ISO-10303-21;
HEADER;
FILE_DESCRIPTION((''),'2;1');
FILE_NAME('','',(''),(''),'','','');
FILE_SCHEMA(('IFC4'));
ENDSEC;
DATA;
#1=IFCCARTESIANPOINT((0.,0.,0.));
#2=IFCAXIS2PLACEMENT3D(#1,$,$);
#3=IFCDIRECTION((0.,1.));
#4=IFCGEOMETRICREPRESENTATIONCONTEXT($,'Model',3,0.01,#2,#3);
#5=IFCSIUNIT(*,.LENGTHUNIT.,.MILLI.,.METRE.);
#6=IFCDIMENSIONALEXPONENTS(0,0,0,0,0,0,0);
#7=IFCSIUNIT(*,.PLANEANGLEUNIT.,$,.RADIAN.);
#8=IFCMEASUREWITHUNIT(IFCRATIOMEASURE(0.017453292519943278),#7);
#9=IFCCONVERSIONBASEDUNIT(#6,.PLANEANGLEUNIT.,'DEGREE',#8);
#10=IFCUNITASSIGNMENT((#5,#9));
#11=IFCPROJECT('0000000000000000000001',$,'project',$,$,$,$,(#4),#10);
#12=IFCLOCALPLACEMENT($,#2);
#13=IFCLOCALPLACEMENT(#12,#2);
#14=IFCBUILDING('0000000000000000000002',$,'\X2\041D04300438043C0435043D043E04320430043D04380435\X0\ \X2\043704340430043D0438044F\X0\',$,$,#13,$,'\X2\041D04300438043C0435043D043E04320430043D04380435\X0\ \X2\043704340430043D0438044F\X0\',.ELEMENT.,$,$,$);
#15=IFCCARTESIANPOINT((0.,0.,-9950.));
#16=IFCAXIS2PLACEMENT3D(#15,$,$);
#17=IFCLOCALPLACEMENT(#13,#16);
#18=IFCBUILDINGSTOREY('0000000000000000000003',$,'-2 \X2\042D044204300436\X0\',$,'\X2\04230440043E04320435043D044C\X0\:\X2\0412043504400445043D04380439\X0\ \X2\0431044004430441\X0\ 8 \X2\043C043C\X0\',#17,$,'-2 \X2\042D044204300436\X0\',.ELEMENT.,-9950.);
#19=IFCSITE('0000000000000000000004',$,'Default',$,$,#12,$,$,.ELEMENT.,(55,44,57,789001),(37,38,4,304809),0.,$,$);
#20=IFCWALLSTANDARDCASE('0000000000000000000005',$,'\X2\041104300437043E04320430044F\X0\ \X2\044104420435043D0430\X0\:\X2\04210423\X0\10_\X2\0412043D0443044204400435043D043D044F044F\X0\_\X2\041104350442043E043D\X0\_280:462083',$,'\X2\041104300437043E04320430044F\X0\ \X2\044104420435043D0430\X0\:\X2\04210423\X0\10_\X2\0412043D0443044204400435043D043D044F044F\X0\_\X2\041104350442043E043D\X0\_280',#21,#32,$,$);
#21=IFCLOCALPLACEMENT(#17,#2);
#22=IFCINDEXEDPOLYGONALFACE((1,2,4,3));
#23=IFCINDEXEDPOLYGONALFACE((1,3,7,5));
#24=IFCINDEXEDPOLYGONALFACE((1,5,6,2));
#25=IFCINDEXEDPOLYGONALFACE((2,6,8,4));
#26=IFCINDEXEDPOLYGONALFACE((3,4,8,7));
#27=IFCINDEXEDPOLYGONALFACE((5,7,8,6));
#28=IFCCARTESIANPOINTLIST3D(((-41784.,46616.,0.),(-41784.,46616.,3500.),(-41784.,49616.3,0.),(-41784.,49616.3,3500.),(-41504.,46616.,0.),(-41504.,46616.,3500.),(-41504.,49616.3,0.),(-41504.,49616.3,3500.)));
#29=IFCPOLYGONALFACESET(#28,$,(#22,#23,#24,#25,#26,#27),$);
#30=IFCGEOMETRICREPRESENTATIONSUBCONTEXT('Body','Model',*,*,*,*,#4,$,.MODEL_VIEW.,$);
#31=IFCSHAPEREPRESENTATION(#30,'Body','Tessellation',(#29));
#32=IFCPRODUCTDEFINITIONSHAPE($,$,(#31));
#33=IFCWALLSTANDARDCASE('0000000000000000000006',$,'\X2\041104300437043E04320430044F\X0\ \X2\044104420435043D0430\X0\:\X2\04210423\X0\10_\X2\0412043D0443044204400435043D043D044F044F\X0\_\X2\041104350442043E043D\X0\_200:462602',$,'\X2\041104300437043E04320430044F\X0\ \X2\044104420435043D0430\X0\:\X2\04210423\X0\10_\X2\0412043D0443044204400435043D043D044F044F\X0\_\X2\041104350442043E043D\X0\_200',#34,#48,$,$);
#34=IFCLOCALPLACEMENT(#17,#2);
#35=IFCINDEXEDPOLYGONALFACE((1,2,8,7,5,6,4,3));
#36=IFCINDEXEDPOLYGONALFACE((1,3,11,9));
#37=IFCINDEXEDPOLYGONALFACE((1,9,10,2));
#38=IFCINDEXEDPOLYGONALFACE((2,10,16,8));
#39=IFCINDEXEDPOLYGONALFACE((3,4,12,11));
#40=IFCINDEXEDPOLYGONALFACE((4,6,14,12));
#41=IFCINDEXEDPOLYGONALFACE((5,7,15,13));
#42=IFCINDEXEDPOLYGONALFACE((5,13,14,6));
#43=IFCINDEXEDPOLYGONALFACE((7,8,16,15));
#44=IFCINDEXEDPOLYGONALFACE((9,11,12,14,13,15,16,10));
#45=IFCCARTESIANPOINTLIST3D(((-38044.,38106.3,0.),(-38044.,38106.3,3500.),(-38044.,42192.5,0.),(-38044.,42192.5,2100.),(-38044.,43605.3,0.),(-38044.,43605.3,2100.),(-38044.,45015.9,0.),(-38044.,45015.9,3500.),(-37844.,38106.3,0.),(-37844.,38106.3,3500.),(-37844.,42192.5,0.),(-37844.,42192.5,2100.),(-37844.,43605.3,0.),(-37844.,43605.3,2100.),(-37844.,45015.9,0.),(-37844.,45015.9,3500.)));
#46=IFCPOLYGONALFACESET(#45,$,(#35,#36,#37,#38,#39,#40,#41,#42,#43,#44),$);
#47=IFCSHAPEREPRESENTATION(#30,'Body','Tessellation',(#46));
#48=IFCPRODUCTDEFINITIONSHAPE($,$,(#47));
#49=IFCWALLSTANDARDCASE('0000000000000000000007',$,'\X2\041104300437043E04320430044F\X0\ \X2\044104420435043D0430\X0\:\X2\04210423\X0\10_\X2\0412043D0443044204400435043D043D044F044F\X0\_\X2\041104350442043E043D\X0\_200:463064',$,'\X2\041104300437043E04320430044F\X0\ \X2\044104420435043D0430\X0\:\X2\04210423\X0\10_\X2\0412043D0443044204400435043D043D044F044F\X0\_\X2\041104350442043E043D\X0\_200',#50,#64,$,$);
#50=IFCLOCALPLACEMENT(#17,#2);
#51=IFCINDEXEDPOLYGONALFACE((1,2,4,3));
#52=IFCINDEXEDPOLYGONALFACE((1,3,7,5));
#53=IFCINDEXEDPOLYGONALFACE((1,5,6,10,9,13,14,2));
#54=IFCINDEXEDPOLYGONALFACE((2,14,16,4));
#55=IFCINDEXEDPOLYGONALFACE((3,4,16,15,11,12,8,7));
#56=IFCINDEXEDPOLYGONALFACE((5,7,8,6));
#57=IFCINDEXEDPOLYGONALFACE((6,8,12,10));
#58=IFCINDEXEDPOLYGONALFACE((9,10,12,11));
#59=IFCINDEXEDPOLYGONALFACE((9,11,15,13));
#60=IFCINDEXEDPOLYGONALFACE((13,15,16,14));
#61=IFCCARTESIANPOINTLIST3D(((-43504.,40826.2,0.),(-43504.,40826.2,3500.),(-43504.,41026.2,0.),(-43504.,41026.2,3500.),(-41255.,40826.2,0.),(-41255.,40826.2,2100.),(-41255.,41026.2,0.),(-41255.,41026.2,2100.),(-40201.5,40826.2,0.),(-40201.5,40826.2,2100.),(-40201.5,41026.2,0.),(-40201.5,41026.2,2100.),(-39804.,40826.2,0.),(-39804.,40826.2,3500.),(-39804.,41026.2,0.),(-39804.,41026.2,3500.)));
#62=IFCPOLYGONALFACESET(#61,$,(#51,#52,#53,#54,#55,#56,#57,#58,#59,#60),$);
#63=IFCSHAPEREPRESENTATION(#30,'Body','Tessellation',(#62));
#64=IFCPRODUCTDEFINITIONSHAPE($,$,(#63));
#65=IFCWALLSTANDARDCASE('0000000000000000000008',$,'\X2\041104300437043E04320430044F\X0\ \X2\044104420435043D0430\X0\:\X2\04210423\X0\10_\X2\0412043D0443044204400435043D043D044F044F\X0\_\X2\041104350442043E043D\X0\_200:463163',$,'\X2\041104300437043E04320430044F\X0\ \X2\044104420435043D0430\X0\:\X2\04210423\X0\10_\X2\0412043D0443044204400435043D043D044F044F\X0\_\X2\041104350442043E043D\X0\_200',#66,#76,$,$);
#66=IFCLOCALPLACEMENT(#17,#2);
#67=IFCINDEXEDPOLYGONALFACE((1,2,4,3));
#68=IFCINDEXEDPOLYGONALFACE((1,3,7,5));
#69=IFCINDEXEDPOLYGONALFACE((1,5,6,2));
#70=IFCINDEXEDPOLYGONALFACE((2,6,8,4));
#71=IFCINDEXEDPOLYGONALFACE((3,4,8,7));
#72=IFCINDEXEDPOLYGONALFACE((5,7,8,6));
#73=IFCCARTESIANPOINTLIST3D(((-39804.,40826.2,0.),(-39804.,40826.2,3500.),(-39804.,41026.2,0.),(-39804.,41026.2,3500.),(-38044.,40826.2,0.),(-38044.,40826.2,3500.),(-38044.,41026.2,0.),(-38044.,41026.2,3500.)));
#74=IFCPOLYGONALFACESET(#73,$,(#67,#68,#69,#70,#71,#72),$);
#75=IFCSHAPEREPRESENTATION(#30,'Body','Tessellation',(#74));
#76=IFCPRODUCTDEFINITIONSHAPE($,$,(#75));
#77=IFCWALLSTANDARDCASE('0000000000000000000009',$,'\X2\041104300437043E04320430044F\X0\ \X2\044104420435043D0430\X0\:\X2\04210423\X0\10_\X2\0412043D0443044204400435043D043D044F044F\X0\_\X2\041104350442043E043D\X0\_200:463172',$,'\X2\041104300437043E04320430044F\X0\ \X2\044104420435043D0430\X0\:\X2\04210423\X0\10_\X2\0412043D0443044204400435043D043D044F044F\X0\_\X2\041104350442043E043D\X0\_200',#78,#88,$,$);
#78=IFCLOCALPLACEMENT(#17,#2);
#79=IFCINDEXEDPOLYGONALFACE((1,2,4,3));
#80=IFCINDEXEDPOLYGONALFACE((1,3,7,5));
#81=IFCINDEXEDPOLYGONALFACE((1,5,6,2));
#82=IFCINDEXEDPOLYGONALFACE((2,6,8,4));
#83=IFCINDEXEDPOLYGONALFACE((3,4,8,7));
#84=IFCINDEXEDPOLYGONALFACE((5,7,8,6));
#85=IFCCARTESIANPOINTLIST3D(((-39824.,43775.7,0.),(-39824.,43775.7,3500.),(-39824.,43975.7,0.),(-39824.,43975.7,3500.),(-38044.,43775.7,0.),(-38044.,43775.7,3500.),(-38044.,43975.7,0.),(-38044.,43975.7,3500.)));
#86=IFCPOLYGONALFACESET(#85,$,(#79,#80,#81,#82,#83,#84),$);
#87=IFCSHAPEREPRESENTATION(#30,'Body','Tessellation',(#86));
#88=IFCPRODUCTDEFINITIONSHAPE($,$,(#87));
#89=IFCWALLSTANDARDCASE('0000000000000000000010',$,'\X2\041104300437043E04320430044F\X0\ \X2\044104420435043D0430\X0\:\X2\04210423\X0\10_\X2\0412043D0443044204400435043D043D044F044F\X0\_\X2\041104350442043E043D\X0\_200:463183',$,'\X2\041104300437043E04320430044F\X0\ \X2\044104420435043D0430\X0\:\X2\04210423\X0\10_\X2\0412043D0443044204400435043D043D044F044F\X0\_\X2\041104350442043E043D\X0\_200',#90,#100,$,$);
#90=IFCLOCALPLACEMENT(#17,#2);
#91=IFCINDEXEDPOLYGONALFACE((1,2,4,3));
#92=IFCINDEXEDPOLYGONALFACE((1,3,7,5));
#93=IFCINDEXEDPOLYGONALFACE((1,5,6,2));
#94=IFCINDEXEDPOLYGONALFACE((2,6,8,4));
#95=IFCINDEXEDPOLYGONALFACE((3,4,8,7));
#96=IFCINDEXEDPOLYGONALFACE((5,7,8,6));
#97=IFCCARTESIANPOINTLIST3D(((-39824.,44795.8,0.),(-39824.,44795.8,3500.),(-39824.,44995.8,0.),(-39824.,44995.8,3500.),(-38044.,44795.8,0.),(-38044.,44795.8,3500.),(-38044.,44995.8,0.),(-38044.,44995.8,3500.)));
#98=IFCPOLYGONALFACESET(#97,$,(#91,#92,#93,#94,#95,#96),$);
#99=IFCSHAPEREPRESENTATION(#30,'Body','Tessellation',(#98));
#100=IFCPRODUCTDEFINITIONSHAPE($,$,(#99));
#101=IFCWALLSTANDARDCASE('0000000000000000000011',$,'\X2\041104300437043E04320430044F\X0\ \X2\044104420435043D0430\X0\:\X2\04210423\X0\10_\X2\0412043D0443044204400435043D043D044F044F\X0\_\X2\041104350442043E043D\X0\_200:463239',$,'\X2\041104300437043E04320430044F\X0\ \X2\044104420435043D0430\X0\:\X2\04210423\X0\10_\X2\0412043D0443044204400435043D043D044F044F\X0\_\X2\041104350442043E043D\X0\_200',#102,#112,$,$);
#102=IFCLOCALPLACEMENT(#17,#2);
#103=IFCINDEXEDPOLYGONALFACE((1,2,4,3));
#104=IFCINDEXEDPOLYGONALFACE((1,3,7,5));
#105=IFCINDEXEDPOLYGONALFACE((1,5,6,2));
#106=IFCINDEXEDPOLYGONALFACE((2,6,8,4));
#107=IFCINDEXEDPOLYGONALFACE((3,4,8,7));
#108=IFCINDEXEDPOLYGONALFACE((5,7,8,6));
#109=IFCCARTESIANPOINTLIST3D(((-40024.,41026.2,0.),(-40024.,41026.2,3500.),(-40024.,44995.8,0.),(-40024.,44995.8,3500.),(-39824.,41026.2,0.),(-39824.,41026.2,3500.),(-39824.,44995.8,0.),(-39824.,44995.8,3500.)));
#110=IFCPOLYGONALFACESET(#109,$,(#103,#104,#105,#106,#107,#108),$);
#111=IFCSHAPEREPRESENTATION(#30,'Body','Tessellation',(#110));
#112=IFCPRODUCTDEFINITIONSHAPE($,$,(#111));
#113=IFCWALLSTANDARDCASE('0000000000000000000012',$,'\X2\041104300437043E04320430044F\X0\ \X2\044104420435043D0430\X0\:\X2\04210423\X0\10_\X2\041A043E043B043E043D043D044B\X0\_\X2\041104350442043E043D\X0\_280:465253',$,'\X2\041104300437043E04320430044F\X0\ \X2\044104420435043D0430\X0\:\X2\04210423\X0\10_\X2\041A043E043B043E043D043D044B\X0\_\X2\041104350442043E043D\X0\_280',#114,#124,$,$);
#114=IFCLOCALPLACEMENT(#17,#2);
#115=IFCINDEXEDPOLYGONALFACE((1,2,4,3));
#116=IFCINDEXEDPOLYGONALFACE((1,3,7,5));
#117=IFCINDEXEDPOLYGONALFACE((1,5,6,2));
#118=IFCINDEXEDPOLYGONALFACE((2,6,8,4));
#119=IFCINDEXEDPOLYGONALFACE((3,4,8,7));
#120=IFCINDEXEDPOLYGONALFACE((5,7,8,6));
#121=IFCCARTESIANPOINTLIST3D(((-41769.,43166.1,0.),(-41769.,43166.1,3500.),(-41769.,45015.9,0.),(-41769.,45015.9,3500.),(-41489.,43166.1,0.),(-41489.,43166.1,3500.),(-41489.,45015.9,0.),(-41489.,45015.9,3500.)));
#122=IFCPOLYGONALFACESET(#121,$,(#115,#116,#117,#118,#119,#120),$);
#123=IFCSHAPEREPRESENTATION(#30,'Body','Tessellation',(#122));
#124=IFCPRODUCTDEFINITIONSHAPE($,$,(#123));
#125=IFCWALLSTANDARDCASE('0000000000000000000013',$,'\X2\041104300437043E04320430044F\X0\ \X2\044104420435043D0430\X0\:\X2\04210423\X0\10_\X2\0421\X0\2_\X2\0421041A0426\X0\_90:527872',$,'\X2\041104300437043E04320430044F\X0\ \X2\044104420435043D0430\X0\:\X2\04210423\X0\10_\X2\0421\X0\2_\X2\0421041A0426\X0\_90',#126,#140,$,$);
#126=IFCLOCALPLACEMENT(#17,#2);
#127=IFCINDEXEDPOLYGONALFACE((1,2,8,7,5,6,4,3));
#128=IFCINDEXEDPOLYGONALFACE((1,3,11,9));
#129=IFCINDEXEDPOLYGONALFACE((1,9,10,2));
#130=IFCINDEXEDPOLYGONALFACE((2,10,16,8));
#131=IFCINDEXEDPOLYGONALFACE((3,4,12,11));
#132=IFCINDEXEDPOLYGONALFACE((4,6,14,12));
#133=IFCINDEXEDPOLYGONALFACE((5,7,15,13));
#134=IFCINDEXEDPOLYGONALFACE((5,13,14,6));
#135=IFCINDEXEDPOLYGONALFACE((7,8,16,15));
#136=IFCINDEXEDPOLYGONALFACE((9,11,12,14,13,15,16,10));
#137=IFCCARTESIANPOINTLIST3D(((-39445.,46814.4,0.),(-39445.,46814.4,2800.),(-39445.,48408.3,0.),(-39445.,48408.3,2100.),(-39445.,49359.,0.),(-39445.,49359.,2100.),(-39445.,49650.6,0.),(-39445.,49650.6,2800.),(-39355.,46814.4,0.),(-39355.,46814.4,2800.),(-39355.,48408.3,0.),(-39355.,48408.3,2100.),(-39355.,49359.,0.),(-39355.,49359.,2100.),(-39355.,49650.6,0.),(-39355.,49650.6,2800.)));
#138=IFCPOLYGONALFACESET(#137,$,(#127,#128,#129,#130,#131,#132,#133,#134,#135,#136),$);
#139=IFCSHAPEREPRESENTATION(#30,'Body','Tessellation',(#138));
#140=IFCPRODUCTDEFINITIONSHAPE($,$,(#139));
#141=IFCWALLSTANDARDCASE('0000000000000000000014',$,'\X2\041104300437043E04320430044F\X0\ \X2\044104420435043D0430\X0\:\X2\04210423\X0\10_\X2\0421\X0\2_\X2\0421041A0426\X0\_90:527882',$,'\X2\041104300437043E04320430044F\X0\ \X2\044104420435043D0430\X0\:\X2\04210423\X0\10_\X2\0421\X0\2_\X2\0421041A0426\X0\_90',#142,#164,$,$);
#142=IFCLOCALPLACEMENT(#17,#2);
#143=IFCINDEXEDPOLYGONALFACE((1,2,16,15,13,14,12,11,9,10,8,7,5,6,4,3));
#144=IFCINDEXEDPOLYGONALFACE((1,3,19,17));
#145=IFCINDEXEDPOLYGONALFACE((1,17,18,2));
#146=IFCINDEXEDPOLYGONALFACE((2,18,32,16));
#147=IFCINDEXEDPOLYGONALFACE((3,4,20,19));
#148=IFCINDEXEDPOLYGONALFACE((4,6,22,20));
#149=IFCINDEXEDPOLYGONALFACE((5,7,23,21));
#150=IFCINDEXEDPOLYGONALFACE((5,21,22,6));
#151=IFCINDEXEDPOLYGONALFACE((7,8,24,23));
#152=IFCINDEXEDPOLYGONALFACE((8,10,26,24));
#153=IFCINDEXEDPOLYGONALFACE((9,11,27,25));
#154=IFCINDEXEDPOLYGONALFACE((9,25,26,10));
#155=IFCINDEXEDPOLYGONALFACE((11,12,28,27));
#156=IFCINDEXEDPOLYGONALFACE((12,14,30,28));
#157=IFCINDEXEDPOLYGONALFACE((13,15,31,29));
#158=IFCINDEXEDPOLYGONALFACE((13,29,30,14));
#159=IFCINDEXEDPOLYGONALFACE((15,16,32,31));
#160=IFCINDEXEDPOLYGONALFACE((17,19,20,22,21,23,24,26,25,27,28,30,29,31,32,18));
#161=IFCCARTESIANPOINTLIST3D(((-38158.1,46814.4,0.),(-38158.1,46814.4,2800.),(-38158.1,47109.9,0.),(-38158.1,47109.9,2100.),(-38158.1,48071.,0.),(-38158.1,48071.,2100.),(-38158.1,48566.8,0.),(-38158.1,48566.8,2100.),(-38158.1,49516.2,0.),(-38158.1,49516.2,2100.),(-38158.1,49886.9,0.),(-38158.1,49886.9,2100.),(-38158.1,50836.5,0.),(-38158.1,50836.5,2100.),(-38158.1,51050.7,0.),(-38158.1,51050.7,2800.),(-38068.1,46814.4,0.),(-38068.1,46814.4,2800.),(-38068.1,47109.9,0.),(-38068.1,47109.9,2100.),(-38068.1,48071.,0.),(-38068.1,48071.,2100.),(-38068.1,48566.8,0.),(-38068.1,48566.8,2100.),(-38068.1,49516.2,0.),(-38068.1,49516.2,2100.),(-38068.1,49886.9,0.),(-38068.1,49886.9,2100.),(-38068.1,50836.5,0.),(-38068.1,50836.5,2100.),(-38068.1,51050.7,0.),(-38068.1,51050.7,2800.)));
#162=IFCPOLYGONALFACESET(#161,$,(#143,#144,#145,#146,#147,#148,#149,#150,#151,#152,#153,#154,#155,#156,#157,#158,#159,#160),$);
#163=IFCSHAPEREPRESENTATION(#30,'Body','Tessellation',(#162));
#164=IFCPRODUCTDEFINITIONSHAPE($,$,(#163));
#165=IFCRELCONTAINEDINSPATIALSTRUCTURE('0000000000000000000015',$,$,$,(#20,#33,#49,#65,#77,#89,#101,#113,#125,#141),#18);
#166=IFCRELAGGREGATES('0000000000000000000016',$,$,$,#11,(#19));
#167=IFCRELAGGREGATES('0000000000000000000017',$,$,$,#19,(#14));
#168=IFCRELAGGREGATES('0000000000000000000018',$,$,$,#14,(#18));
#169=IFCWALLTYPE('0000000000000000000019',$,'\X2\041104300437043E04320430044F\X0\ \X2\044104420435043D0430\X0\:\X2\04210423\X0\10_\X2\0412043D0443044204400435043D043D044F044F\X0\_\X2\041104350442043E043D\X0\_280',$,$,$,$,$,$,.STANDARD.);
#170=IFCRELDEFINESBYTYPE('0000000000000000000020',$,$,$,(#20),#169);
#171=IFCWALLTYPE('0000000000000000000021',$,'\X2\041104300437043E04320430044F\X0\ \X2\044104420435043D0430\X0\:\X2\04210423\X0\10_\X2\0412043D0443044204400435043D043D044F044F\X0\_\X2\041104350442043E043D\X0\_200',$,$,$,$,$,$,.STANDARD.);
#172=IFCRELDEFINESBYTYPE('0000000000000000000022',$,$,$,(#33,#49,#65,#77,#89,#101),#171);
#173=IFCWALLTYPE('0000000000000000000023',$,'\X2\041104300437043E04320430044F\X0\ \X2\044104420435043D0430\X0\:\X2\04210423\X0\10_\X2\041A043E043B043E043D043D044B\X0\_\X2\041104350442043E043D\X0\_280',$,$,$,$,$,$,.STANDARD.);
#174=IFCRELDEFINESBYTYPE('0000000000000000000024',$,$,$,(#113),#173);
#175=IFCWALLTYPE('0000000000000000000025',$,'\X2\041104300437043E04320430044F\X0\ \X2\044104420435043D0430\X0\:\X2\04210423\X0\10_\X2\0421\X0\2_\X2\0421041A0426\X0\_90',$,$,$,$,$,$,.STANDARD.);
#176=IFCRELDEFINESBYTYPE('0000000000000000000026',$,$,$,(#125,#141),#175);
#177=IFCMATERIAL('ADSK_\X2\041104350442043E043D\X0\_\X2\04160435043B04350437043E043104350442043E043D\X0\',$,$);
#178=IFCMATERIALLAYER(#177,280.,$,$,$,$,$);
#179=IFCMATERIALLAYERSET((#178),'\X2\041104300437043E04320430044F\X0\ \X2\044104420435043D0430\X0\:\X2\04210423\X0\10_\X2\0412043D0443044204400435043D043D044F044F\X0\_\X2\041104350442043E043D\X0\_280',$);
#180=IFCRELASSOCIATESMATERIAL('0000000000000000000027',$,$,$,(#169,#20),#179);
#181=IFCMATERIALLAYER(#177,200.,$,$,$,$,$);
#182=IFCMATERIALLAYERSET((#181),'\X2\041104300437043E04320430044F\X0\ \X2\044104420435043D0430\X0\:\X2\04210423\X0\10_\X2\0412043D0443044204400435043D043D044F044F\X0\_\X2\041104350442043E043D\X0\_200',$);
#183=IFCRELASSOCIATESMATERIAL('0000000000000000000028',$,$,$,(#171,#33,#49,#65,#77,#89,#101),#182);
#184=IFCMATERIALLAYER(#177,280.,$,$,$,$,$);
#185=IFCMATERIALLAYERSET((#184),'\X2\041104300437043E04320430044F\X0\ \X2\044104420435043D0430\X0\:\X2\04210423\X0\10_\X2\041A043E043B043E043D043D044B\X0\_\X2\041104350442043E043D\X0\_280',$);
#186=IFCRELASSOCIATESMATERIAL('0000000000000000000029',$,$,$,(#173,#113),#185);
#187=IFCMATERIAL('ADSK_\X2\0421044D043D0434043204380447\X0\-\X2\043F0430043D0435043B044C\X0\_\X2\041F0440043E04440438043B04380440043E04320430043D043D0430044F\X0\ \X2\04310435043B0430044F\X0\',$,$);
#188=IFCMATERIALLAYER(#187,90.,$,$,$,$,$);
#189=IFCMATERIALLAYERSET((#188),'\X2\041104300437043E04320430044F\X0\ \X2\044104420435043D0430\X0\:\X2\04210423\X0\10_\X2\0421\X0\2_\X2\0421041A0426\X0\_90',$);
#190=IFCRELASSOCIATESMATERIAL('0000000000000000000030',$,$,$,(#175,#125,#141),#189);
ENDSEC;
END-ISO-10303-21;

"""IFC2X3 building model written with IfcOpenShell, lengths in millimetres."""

from ifc_helpers import new_model, entity, si_unit, converted_unit, direction, frame, frame_2d, origin, place, context, subcontext, project, spatial, rectangle, extrude, material, layer, layer_set, layer_usage, type_object, element, save


model = new_model("IFC2X3")

# Units and contexts
model_context = context("Model", 3, precision=0.01, world=origin(), true_north=direction((0.0, 1.0)))
body_context = subcontext(model_context, "Body", "Model", "MODEL_VIEW")
ifc_project = project(units=[si_unit("LENGTHUNIT", "METRE", prefix="MILLI"), converted_unit("PLANEANGLEUNIT", "DEGREE", entity("IfcRatioMeasure", 0.017453292519943278), si_unit("PLANEANGLEUNIT", "RADIAN"), dimensions=[0, 0, 0, 0, 0, 0, 0])], contexts=[model_context])

# Site, building, storey
site_placement = place(None, origin())
site = spatial("IfcSite", under=ifc_project, at=site_placement, Name="Default", CompositionType="ELEMENT", RefLatitude=(55, 44, 57, 789001), RefLongitude=(37, 38, 4, 304809), RefElevation=0.0)
building_placement = place(site_placement, origin())
building = spatial("IfcBuilding", under=site, at=building_placement, Name="Наименование здания", LongName="Наименование здания", CompositionType="ELEMENT")
storey_placement = place(building_placement, frame((0.0, 0.0, -9950.0)))
storey = spatial("IfcBuildingStorey", under=building, at=storey_placement, Name="-2 Этаж", ObjectType="Уровень:Верхний брус 8 мм", LongName="-2 Этаж", CompositionType="ELEMENT", Elevation=-9950.0)

# Wall
ifc_material_1 = material(Name="ADSK_Бетон_Железобетон")
ifc_layer_1 = layer(ifc_material_1, 280.0)
ifc_layer_set_1 = layer_set([ifc_layer_1], Name="Базовая стена:СУ10_Внутренняя_Бетон_280")
ifc_layer_usage_1 = layer_usage(ifc_layer_set_1, "AXIS2", "NEGATIVE", 140.0)
wall_type_1 = type_object("IfcWallType", Name="Базовая стена:СУ10_Внутренняя_Бетон_280", PredefinedType="STANDARD", material=ifc_layer_set_1)
wall_1_placement = place(storey_placement, frame((-41644.0, 49616.3, 0.0), z_axis=(0.0, 0.0, 1.0), x_axis=(0.0, -1.0, 0.0)))
element("IfcWallStandardCase", 1, at=wall_1_placement, inside=storey, type_object=wall_type_1, material=ifc_layer_usage_1, Name="Базовая стена:СУ10_Внутренняя_Бетон_280:462083", ObjectType="Базовая стена:СУ10_Внутренняя_Бетон_280", context=body_context, shape_type="SweptSolid", body=[
    extrude(rectangle(XDim=3000.3, YDim=280.0, at=frame_2d((1500.2, 0.0), x_axis=(-1.0, 0.0))), origin(), (0.0, 0.0, 1.0), 3500.0),
])

# Walls, openings
ifc_layer_2 = layer(ifc_material_1, 200.0)
ifc_layer_set_2 = layer_set([ifc_layer_2], Name="Базовая стена:СУ10_Внутренняя_Бетон_200")
ifc_layer_usage_2 = layer_usage(ifc_layer_set_2, "AXIS2", "NEGATIVE", 100.0)
wall_type_2 = type_object("IfcWallType", Name="Базовая стена:СУ10_Внутренняя_Бетон_200", PredefinedType="STANDARD", material=ifc_layer_set_2)
wall_2_placement = place(storey_placement, frame((-37944.0, 45015.9, 0.0), z_axis=(0.0, 0.0, 1.0), x_axis=(0.0, -1.0, 0.0)))
wall_2 = element("IfcWallStandardCase", 2, at=wall_2_placement, inside=storey, type_object=wall_type_2, material=ifc_layer_usage_2, Name="Базовая стена:СУ10_Внутренняя_Бетон_200:462602", ObjectType="Базовая стена:СУ10_Внутренняя_Бетон_200", context=body_context, shape_type="SweptSolid", body=[
    extrude(rectangle(XDim=6909.7, YDim=200.0, at=frame_2d((3454.8, 0.0), x_axis=(1.0, 0.0))), origin(), (0.0, 0.0, 1.0), 3500.0),
])
opening_1_placement = place(wall_2_placement, origin())
element("IfcOpeningElement", 3, at=opening_1_placement, cuts=wall_2, ObjectType="Opening", context=body_context, shape_type="SweptSolid", body=[
    extrude(rectangle(XDim=2100.0, YDim=1412.8, at=frame_2d((0.0, 0.0), x_axis=(1.0, 0.0))), frame((2117.1, -100.0, 1050.0), z_axis=(0.0, 1.0, 0.0), x_axis=(0.0, 0.0, -1.0)), (0.0, 0.0, 1.0), 200.0),
])
wall_3_placement = place(storey_placement, frame((-39804.0, 40926.2, 0.0), z_axis=(0.0, 0.0, 1.0), x_axis=(-1.0, 0.0, 0.0)))
wall_3 = element("IfcWallStandardCase", 4, at=wall_3_placement, inside=storey, type_object=wall_type_2, material=ifc_layer_usage_2, Name="Базовая стена:СУ10_Внутренняя_Бетон_200:463064", ObjectType="Базовая стена:СУ10_Внутренняя_Бетон_200", context=body_context, shape_type="SweptSolid", body=[
    extrude(rectangle(XDim=3700.0, YDim=200.0, at=frame_2d((1850.0, 0.0), x_axis=(-1.0, 0.0))), origin(), (0.0, 0.0, 1.0), 3500.0),
])
opening_2_placement = place(wall_3_placement, origin())
element("IfcOpeningElement", 5, at=opening_2_placement, cuts=wall_3, ObjectType="Opening", context=body_context, shape_type="SweptSolid", body=[
    extrude(rectangle(XDim=2100.0, YDim=1053.6, at=frame_2d((0.0, 0.0), x_axis=(1.0, 0.0))), frame((924.3, -100.0, 1050.0), z_axis=(0.0, 1.0, 0.0), x_axis=(0.0, 0.0, -1.0)), (0.0, 0.0, 1.0), 200.0),
])

# Walls
wall_4_placement = place(storey_placement, frame((-38044.0, 40926.2, 0.0), z_axis=(0.0, 0.0, 1.0), x_axis=(-1.0, 0.0, 0.0)))
element("IfcWallStandardCase", 6, at=wall_4_placement, inside=storey, type_object=wall_type_2, material=ifc_layer_usage_2, Name="Базовая стена:СУ10_Внутренняя_Бетон_200:463163", ObjectType="Базовая стена:СУ10_Внутренняя_Бетон_200", context=body_context, shape_type="SweptSolid", body=[
    extrude(rectangle(XDim=1760.0, YDim=200.0, at=frame_2d((880.0, 0.0), x_axis=(-1.0, 0.0))), origin(), (0.0, 0.0, 1.0), 3500.0),
])
wall_5_placement = place(storey_placement, frame((-38044.0, 43875.7, 0.0), z_axis=(0.0, 0.0, 1.0), x_axis=(-1.0, 0.0, 0.0)))
element("IfcWallStandardCase", 7, at=wall_5_placement, inside=storey, type_object=wall_type_2, material=ifc_layer_usage_2, Name="Базовая стена:СУ10_Внутренняя_Бетон_200:463172", ObjectType="Базовая стена:СУ10_Внутренняя_Бетон_200", context=body_context, shape_type="SweptSolid", body=[
    extrude(rectangle(XDim=1780.0, YDim=200.0, at=frame_2d((890.0, 0.0), x_axis=(-1.0, 0.0))), origin(), (0.0, 0.0, 1.0), 3500.0),
])
wall_6_placement = place(storey_placement, frame((-38044.0, 44895.8, 0.0), z_axis=(0.0, 0.0, 1.0), x_axis=(-1.0, 0.0, 0.0)))
element("IfcWallStandardCase", 8, at=wall_6_placement, inside=storey, type_object=wall_type_2, material=ifc_layer_usage_2, Name="Базовая стена:СУ10_Внутренняя_Бетон_200:463183", ObjectType="Базовая стена:СУ10_Внутренняя_Бетон_200", context=body_context, shape_type="SweptSolid", body=[
    extrude(rectangle(XDim=1780.0, YDim=200.0, at=frame_2d((890.0, 0.0), x_axis=(-1.0, 0.0))), origin(), (0.0, 0.0, 1.0), 3500.0),
])
wall_7_placement = place(storey_placement, frame((-39924.0, 44995.8, 0.0), z_axis=(0.0, 0.0, 1.0), x_axis=(0.0, -1.0, 0.0)))
element("IfcWallStandardCase", 9, at=wall_7_placement, inside=storey, type_object=wall_type_2, material=ifc_layer_usage_2, Name="Базовая стена:СУ10_Внутренняя_Бетон_200:463239", ObjectType="Базовая стена:СУ10_Внутренняя_Бетон_200", context=body_context, shape_type="SweptSolid", body=[
    extrude(rectangle(XDim=3969.7, YDim=200.0, at=frame_2d((1984.8, 0.0), x_axis=(-1.0, 0.0))), origin(), (0.0, 0.0, 1.0), 3500.0),
])
ifc_layer_3 = layer(ifc_material_1, 280.0)
ifc_layer_set_3 = layer_set([ifc_layer_3], Name="Базовая стена:СУ10_Колонны_Бетон_280")
ifc_layer_usage_3 = layer_usage(ifc_layer_set_3, "AXIS2", "NEGATIVE", 140.0)
wall_type_3 = type_object("IfcWallType", Name="Базовая стена:СУ10_Колонны_Бетон_280", PredefinedType="STANDARD", material=ifc_layer_set_3)
wall_8_placement = place(storey_placement, frame((-41629.0, 45015.9, 0.0), z_axis=(0.0, 0.0, 1.0), x_axis=(0.0, -1.0, 0.0)))
element("IfcWallStandardCase", 10, at=wall_8_placement, inside=storey, type_object=wall_type_3, material=ifc_layer_usage_3, Name="Базовая стена:СУ10_Колонны_Бетон_280:465253", ObjectType="Базовая стена:СУ10_Колонны_Бетон_280", context=body_context, shape_type="SweptSolid", body=[
    extrude(rectangle(XDim=1849.8, YDim=280.0, at=frame_2d((924.9, 0.0), x_axis=(-1.0, 0.0))), origin(), (0.0, 0.0, 1.0), 3500.0),
])

# Wall, opening
ifc_material_2 = material(Name="ADSK_Сэндвич-панель_Профилированная белая")
ifc_layer_4 = layer(ifc_material_2, 90.0)
ifc_layer_set_4 = layer_set([ifc_layer_4], Name="Базовая стена:СУ10_С2_СКЦ_90")
ifc_layer_usage_4 = layer_usage(ifc_layer_set_4, "AXIS2", "NEGATIVE", 45.0)
wall_type_4 = type_object("IfcWallType", Name="Базовая стена:СУ10_С2_СКЦ_90", PredefinedType="STANDARD", material=ifc_layer_set_4)
wall_9_placement = place(storey_placement, frame((-39400.0, 49650.6, 0.0), z_axis=(0.0, 0.0, 1.0), x_axis=(0.0, -1.0, 0.0)))
wall_9 = element("IfcWallStandardCase", 11, at=wall_9_placement, inside=storey, type_object=wall_type_4, material=ifc_layer_usage_4, Name="Базовая стена:СУ10_С2_СКЦ_90:527872", ObjectType="Базовая стена:СУ10_С2_СКЦ_90", context=body_context, shape_type="SweptSolid", body=[
    extrude(rectangle(XDim=2836.2, YDim=90.0, at=frame_2d((1418.1, 0.0), x_axis=(-1.0, 0.0))), origin(), (0.0, 0.0, 1.0), 2800.0),
])
opening_3_placement = place(wall_9_placement, origin())
element("IfcOpeningElement", 12, at=opening_3_placement, cuts=wall_9, ObjectType="Opening", context=body_context, shape_type="SweptSolid", body=[
    extrude(rectangle(XDim=2100.0, YDim=950.7, at=frame_2d((0.0, 0.0), x_axis=(1.0, 0.0))), frame((767.0, -45.0, 1050.0), z_axis=(0.0, 1.0, 0.0), x_axis=(0.0, 0.0, -1.0)), (0.0, 0.0, 1.0), 90.0),
])

# Wall, openings
wall_10_placement = place(storey_placement, frame((-38113.1, 51050.7, 0.0), z_axis=(0.0, 0.0, 1.0), x_axis=(0.0, -1.0, 0.0)))
wall_10 = element("IfcWallStandardCase", 13, at=wall_10_placement, inside=storey, type_object=wall_type_4, material=ifc_layer_usage_4, Name="Базовая стена:СУ10_С2_СКЦ_90:527882", ObjectType="Базовая стена:СУ10_С2_СКЦ_90", context=body_context, shape_type="SweptSolid", body=[
    extrude(rectangle(XDim=4236.3, YDim=90.0, at=frame_2d((2118.2, 0.0), x_axis=(1.0, 0.0))), origin(), (0.0, 0.0, 1.0), 2800.0),
])
opening_4_placement = place(wall_10_placement, origin())
element("IfcOpeningElement", 14, at=opening_4_placement, cuts=wall_10, ObjectType="Opening", context=body_context, shape_type="SweptSolid", body=[
    extrude(rectangle(XDim=2100.0, YDim=949.7, at=frame_2d((0.0, 0.0), x_axis=(1.0, 0.0))), frame((689.0, -45.0, 1050.0), z_axis=(0.0, 1.0, 0.0), x_axis=(0.0, 0.0, -1.0)), (0.0, 0.0, 1.0), 90.0),
])
opening_5_placement = place(wall_10_placement, origin())
element("IfcOpeningElement", 15, at=opening_5_placement, cuts=wall_10, ObjectType="Opening", context=body_context, shape_type="SweptSolid", body=[
    extrude(rectangle(XDim=2100.0, YDim=949.4, at=frame_2d((0.0, 0.0), x_axis=(1.0, 0.0))), frame((2009.2, -45.0, 1050.0), z_axis=(0.0, 1.0, 0.0), x_axis=(0.0, 0.0, -1.0)), (0.0, 0.0, 1.0), 90.0),
])
opening_6_placement = place(wall_10_placement, origin())
element("IfcOpeningElement", 16, at=opening_6_placement, cuts=wall_10, ObjectType="Opening", context=body_context, shape_type="SweptSolid", body=[
    extrude(rectangle(XDim=2100.0, YDim=961.1, at=frame_2d((0.0, 0.0), x_axis=(1.0, 0.0))), frame((3460.3, -45.0, 1050.0), z_axis=(0.0, 1.0, 0.0), x_axis=(0.0, 0.0, -1.0)), (0.0, 0.0, 1.0), 90.0),
])

save(model, "model.ifc")
